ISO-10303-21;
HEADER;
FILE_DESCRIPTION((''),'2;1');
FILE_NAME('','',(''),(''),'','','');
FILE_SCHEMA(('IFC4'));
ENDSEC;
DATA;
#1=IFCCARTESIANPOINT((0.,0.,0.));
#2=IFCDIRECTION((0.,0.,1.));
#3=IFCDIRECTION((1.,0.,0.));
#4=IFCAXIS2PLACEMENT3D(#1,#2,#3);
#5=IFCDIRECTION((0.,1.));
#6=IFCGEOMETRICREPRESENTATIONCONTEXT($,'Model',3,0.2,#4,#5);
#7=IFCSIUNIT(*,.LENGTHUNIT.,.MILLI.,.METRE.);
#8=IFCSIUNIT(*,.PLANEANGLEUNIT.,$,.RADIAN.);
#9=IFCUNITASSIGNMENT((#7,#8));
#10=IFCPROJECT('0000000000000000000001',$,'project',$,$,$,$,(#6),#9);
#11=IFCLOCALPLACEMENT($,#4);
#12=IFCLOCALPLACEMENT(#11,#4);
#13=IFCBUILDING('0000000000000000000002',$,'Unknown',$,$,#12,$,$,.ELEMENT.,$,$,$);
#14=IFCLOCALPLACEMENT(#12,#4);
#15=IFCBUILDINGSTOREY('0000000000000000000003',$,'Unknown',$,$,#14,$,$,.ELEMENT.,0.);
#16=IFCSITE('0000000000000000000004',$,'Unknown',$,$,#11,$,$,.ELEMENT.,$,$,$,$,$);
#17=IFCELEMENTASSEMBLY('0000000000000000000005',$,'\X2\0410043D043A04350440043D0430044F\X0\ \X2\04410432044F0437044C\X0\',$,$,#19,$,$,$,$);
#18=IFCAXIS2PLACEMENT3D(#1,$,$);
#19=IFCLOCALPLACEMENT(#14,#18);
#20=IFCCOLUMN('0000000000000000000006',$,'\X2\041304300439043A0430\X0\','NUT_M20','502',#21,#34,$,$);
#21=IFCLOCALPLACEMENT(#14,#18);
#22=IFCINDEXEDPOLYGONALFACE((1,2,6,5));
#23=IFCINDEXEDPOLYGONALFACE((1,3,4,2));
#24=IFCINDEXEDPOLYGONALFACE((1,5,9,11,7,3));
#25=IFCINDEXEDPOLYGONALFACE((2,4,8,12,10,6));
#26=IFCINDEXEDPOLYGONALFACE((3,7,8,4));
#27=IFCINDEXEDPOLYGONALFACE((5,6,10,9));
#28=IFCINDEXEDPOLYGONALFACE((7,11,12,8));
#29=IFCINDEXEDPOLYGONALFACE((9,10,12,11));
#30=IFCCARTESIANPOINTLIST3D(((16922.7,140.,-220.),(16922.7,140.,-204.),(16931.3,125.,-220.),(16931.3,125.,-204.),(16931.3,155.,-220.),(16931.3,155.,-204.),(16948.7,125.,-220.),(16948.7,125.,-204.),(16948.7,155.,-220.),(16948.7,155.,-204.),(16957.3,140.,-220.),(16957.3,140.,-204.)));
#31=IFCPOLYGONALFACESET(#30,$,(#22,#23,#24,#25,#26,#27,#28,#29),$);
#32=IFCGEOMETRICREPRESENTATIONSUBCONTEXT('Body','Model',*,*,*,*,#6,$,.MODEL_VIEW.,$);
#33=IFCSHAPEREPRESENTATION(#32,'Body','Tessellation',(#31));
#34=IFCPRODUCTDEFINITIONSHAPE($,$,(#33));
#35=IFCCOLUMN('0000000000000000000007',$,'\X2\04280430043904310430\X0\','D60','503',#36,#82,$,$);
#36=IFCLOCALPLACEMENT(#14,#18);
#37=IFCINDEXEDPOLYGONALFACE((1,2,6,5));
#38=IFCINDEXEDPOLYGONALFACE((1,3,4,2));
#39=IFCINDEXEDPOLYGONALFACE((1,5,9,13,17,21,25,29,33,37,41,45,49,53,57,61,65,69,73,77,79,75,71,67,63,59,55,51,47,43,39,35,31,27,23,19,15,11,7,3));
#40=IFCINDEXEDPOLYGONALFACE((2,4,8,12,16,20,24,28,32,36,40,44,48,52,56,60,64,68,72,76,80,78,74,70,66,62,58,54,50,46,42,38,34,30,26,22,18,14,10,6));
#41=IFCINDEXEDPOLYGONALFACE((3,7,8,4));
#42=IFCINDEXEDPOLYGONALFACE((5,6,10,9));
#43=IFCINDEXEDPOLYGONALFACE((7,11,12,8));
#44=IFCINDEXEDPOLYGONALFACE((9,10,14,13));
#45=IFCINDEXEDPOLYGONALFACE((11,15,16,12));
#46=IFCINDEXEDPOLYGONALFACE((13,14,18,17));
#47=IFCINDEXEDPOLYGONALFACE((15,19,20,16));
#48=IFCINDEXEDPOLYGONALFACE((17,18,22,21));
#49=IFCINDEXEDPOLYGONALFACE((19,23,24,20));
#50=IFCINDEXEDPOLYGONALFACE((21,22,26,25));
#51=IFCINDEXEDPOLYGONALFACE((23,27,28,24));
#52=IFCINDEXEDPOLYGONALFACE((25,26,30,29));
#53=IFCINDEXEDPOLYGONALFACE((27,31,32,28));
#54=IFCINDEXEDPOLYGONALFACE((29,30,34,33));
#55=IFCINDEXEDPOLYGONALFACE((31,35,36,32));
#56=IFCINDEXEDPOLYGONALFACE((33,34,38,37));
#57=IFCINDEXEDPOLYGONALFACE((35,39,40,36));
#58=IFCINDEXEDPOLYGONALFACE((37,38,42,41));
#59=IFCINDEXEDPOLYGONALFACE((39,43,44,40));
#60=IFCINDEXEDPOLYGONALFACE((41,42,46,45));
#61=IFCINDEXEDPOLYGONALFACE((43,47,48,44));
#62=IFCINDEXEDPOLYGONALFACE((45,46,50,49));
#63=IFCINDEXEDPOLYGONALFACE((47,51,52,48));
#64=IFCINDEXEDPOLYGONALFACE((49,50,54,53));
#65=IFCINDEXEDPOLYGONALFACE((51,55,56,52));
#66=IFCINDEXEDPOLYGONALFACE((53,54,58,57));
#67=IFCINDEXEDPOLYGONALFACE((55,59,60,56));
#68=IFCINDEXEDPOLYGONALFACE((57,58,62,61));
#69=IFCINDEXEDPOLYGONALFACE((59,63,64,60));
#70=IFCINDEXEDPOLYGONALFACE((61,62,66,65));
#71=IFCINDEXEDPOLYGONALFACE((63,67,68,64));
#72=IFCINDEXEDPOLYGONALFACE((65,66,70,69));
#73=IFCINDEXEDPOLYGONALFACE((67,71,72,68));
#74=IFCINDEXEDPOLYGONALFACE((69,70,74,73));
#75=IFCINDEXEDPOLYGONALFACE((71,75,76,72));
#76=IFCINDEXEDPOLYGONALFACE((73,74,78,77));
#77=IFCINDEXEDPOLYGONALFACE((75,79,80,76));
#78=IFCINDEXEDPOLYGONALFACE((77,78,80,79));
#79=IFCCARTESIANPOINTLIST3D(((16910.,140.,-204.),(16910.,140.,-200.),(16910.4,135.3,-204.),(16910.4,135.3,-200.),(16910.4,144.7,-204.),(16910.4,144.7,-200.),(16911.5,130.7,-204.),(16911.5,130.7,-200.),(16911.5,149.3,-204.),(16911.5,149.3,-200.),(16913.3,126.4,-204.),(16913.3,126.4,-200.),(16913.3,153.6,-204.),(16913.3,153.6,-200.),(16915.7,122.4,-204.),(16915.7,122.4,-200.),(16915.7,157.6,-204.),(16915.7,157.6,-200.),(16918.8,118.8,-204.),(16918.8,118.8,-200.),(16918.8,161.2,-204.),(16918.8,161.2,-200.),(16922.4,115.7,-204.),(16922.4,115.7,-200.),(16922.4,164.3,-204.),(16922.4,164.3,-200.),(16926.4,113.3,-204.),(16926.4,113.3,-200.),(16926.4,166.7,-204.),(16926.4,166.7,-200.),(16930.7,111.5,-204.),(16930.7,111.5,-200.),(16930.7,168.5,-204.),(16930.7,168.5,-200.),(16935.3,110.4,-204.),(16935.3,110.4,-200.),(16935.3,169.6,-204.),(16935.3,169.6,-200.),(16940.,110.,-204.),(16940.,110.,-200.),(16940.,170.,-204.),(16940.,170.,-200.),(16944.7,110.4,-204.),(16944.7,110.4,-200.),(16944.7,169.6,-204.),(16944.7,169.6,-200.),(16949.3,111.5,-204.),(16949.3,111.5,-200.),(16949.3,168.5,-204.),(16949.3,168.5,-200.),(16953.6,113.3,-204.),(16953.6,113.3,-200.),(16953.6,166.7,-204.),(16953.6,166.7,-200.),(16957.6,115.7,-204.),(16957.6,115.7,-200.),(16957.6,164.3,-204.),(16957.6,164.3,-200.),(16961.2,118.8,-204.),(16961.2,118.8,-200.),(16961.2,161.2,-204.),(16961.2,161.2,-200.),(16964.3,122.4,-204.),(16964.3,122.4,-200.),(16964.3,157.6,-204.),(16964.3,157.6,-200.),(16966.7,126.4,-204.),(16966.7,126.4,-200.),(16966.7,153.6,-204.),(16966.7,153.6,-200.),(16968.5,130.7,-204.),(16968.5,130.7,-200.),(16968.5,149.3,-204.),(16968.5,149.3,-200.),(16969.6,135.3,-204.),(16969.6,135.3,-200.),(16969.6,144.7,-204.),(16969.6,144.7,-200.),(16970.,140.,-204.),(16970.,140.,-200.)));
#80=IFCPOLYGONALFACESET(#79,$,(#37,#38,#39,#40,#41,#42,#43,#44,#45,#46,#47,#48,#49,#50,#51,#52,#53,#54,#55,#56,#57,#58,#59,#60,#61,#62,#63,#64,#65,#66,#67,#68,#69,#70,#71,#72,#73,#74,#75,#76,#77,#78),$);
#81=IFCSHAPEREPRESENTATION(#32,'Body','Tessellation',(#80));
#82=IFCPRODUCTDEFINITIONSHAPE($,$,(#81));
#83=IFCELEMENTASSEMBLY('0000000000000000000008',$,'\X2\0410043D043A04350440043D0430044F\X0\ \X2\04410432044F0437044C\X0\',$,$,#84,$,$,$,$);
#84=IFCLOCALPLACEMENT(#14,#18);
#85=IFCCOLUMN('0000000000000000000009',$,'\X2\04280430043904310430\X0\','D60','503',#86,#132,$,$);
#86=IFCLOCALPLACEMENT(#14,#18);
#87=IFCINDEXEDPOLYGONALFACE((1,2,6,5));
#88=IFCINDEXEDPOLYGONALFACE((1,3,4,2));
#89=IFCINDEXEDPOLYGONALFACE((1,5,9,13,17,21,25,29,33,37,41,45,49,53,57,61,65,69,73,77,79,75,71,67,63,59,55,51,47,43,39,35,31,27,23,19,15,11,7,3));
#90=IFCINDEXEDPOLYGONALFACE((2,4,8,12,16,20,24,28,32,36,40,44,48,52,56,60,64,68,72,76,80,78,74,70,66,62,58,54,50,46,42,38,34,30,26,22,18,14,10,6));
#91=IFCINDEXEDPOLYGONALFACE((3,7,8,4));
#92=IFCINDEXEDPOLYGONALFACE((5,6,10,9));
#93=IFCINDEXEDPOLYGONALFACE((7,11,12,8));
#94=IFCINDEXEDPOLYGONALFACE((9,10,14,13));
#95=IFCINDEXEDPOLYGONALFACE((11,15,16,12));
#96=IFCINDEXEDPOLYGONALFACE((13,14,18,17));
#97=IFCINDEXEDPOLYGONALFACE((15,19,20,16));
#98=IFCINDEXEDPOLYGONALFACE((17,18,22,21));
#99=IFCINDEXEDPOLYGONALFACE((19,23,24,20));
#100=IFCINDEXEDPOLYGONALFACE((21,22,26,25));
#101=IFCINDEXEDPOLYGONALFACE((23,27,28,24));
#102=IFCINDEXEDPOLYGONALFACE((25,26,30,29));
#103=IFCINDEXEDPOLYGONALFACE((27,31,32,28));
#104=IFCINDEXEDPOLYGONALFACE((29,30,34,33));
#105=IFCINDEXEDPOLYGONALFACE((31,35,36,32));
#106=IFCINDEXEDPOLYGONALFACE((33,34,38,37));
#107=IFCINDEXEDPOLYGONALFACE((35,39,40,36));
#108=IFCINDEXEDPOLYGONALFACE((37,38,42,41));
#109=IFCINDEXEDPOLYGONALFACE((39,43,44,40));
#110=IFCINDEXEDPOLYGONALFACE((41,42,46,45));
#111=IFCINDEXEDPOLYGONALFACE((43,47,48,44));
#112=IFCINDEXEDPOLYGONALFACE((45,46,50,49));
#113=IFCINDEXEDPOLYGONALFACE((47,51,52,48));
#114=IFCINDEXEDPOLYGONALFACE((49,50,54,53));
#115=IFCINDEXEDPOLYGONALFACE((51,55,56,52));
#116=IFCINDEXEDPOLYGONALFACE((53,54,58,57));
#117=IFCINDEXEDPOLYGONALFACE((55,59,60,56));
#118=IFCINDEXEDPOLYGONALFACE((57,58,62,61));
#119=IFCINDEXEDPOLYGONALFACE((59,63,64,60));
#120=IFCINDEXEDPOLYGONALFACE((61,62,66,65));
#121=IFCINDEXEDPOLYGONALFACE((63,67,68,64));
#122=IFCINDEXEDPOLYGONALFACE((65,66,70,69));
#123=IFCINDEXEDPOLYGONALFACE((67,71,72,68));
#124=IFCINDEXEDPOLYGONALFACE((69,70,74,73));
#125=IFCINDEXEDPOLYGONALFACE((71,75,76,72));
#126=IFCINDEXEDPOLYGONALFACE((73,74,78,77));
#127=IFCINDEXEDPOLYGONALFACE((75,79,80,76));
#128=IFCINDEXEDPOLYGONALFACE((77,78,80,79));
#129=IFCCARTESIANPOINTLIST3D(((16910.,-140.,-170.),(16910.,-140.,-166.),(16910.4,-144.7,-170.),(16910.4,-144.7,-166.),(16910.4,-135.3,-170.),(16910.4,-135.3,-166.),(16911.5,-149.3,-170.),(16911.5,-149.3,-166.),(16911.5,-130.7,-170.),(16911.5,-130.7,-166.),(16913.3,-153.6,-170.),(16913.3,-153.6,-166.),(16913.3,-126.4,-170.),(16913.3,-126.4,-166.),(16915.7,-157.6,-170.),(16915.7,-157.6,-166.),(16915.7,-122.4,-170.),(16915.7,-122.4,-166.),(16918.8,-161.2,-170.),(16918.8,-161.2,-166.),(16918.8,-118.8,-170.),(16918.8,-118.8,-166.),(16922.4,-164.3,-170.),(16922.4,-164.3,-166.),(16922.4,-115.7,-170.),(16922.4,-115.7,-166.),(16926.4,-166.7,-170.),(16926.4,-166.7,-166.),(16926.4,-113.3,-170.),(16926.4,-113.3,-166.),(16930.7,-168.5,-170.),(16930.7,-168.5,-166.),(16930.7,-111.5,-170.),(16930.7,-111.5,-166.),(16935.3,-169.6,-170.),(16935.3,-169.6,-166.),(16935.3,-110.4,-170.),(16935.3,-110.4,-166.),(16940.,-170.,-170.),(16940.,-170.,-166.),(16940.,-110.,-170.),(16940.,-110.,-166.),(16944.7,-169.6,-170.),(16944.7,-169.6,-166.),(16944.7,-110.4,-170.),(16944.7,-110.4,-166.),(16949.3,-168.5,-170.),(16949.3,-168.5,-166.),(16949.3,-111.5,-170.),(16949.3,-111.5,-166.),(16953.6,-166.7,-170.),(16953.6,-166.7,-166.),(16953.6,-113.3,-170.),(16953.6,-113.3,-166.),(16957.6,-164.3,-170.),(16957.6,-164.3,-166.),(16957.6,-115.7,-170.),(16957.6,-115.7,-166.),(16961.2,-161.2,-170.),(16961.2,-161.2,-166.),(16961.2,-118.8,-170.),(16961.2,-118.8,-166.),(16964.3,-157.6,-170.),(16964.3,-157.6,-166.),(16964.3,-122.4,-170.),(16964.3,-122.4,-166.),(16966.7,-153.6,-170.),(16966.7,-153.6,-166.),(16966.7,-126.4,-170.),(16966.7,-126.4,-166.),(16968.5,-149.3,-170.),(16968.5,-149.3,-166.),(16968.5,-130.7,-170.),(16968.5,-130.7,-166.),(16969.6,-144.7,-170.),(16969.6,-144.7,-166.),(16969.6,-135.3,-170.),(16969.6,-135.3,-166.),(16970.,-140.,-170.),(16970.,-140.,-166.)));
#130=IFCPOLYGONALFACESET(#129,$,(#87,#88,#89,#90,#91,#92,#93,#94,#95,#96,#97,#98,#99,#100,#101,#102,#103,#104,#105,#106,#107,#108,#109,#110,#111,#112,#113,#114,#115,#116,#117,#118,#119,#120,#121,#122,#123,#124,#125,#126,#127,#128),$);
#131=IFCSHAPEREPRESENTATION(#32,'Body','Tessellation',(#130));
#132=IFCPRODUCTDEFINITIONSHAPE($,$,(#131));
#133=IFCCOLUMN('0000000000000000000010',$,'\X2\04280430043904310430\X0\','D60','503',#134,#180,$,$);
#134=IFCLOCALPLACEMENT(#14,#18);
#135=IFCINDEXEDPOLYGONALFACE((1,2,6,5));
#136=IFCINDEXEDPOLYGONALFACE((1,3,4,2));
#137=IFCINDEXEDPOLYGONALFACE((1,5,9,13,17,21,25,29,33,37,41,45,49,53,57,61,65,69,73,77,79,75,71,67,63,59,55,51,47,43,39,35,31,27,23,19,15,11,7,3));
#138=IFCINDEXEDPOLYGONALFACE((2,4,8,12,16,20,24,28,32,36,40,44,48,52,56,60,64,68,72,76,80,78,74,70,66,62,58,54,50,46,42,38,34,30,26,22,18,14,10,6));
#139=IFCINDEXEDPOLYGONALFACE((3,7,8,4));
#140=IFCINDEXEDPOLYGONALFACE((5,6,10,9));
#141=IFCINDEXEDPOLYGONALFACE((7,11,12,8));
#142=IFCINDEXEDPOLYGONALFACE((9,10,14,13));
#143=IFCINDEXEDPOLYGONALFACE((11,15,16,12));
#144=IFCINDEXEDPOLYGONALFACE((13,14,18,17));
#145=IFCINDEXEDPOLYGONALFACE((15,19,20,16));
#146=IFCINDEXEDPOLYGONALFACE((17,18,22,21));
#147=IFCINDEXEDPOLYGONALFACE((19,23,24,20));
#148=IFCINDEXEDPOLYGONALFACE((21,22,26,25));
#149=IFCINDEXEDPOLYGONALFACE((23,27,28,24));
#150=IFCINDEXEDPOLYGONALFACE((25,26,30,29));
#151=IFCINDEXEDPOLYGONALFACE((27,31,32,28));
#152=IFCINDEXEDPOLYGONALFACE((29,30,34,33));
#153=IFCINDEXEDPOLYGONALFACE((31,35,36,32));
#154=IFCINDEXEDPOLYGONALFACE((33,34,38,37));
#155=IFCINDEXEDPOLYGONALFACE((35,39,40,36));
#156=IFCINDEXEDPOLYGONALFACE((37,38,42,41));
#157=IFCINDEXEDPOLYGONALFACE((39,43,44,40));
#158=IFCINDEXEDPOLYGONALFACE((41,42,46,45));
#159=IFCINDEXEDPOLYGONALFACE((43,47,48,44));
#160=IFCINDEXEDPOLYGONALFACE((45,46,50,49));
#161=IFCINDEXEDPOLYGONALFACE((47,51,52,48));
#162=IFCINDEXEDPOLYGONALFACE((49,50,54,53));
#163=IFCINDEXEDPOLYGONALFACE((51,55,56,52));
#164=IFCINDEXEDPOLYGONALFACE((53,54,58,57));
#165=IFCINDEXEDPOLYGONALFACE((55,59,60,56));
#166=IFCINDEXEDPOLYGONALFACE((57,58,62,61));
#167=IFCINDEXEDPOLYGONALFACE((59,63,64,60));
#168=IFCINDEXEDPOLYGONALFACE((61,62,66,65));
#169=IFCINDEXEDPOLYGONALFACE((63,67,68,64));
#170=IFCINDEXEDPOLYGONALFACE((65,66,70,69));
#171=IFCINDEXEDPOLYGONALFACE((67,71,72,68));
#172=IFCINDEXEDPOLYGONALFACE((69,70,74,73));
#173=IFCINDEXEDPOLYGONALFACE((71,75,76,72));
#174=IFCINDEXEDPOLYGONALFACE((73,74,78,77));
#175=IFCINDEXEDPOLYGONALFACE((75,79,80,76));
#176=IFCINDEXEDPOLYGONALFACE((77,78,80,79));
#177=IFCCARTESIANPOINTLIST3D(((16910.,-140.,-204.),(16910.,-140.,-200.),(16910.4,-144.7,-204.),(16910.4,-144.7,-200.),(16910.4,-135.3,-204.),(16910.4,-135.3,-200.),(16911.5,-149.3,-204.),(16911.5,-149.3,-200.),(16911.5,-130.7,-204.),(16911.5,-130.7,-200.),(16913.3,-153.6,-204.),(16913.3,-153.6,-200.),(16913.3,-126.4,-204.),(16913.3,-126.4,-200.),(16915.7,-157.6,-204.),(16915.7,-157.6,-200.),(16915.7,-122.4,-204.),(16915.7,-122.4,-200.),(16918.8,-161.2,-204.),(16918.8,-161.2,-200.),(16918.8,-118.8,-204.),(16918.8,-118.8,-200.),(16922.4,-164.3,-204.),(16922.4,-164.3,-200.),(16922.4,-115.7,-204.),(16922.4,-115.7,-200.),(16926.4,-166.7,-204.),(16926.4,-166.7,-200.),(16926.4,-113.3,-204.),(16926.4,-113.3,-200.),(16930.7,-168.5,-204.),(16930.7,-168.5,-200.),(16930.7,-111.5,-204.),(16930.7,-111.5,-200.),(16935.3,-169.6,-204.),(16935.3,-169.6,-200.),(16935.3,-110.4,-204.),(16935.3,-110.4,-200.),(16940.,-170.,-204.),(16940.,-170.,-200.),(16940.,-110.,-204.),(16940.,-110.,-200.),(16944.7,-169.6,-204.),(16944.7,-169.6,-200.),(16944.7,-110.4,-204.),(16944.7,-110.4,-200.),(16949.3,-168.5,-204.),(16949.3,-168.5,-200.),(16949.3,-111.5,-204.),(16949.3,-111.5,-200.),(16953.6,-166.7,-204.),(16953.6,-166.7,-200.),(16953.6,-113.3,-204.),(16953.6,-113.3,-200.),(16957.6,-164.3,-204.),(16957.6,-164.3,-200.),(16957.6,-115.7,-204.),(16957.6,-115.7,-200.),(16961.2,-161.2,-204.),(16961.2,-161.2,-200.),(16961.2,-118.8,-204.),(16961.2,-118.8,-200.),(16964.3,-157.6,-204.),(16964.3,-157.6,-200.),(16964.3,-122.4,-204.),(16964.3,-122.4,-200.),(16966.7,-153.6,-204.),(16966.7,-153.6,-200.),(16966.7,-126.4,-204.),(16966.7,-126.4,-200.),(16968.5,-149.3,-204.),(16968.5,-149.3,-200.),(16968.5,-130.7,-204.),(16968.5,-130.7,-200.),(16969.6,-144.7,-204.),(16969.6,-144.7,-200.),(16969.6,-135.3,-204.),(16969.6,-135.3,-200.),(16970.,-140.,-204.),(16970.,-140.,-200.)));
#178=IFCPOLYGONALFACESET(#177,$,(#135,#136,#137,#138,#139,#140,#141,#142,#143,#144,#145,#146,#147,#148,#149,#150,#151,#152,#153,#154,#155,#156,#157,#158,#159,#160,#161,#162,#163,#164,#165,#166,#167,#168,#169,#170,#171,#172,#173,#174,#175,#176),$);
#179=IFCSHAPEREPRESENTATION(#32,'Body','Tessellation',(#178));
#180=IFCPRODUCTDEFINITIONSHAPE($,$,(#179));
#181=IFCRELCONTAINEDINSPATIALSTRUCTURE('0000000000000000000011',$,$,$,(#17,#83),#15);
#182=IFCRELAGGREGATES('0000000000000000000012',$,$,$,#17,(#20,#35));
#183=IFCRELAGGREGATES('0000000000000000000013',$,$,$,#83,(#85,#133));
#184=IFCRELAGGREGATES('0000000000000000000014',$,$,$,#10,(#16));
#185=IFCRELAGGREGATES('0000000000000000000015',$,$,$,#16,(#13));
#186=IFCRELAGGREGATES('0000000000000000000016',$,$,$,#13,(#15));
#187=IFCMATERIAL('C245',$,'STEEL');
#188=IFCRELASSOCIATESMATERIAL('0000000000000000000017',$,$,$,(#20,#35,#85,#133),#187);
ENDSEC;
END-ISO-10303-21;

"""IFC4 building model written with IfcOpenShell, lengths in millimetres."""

from ifc_helpers import new_model, si_unit, direction, frame, origin_with_axes, place, context, subcontext, project, spatial, line, indexed_curve, outline, extrude, material, element, aggregate, save


model = new_model("IFC4")

# Units and contexts
model_context = context("Model", 3, precision=0.2, world=origin_with_axes(), true_north=direction((0.0, 1.0)))
body_context = subcontext(model_context, "Body", "Model", "MODEL_VIEW")
ifc_project = project(units=[si_unit("LENGTHUNIT", "METRE", prefix="MILLI"), si_unit("PLANEANGLEUNIT", "RADIAN")], contexts=[model_context])

# Site, building, storey
site_placement = place(None, origin_with_axes())
site = spatial("IfcSite", under=ifc_project, at=site_placement, Name="Unknown", CompositionType="ELEMENT")
building_placement = place(site_placement, origin_with_axes())
building = spatial("IfcBuilding", under=site, at=building_placement, Name="Unknown", CompositionType="ELEMENT")
storey_placement = place(building_placement, origin_with_axes())
storey = spatial("IfcBuildingStorey", under=building, at=storey_placement, Name="Unknown", CompositionType="ELEMENT", Elevation=0.0)

# Element assemblies, columns
assembly_1_placement = place(storey_placement, frame((16940.0, 140.0, -125.0), z_axis=(-1.0, 0.0, 0.0), x_axis=(0.0, 0.0, -1.0)))
assembly_1 = element("IfcElementAssembly", 1, at=assembly_1_placement, inside=storey, Name="Анкерная связь")
ifc_material_1 = material(Name="C245", Category="STEEL")
column_1_placement = place(assembly_1_placement, frame((79.0, 0.0, 0.0), z_axis=(0.0, 0.0, -1.0), x_axis=(1.0, 0.0, 0.0)))
column_1 = element("IfcColumn", 2, at=column_1_placement, material=ifc_material_1, Name="Гайка", Description="NUT_M20", ObjectType="502", context=body_context, shape_type="SolidModel", body=[
    extrude(outline(indexed_curve([(8.7, -15.0), (17.3, 0.0), (8.7, 15.0), (-8.7, 15.0), (-17.3, 0.0), (-8.7, -15.0)], segments=[line(1, 2, 3, 4, 5, 6, 1)])), frame((0.0, 0.0, 0.0), z_axis=(-1.0, 0.0, 0.0), x_axis=(0.0, 0.0, 1.0)), (0.0, 0.0, -1.0), 16.0),
])
column_2_placement = place(assembly_1_placement, frame((75.0, 0.0, 0.0), z_axis=(0.0, -1.0, 0.0), x_axis=(1.0, 0.0, 0.0)))
column_2 = element("IfcColumn", 3, at=column_2_placement, material=ifc_material_1, Name="Шайба", Description="D60", ObjectType="503", context=body_context, shape_type="SolidModel", body=[
    extrude(outline(indexed_curve([(30.0, 0.0), (29.6, 4.7), (28.5, 9.3), (26.7, 13.6), (24.3, 17.6), (21.2, 21.2), (17.6, 24.3), (13.6, 26.7), (9.3, 28.5), (4.7, 29.6), (0.0, 30.0), (-4.7, 29.6), (-9.3, 28.5), (-13.6, 26.7), (-17.6, 24.3), (-21.2, 21.2), (-24.3, 17.6), (-26.7, 13.6), (-28.5, 9.3), (-29.6, 4.7), (-30.0, 0.0), (-29.6, -4.7), (-28.5, -9.3), (-26.7, -13.6), (-24.3, -17.6), (-21.2, -21.2), (-17.6, -24.3), (-13.6, -26.7), (-9.3, -28.5), (-4.7, -29.6), (0.0, -30.0), (4.7, -29.6), (9.3, -28.5), (13.6, -26.7), (17.6, -24.3), (21.2, -21.2), (24.3, -17.6), (26.7, -13.6), (28.5, -9.3), (29.6, -4.7)], segments=[line(1, 2, 3, 4, 5, 6, 7, 8, 9, 10, 11, 12, 13, 14, 15, 16, 17, 18, 19, 20, 21, 22, 23, 24, 25, 26, 27, 28, 29, 30, 31, 32, 33, 34, 35, 36, 37, 38, 39, 40, 1)])), frame((0.0, 0.0, 0.0), z_axis=(-1.0, 0.0, 0.0), x_axis=(0.0, 0.0, 1.0)), (0.0, 0.0, -1.0), 4.0),
])
assembly_2_placement = place(storey_placement, frame((16940.0, -140.0, -125.0), z_axis=(1.0, 0.0, 0.0), x_axis=(0.0, 0.0, -1.0)))
assembly_2 = element("IfcElementAssembly", 4, at=assembly_2_placement, inside=storey, Name="Анкерная связь")
column_3_placement = place(assembly_2_placement, frame((41.0, 0.0, 0.0), z_axis=(0.0, 0.0, 1.0), x_axis=(1.0, 0.0, 0.0)))
column_3 = element("IfcColumn", 5, at=column_3_placement, material=ifc_material_1, Name="Шайба", Description="D60", ObjectType="503", context=body_context, shape_type="SolidModel", body=[
    extrude(outline(indexed_curve([(30.0, 0.0), (29.6, 4.7), (28.5, 9.3), (26.7, 13.6), (24.3, 17.6), (21.2, 21.2), (17.6, 24.3), (13.6, 26.7), (9.3, 28.5), (4.7, 29.6), (0.0, 30.0), (-4.7, 29.6), (-9.3, 28.5), (-13.6, 26.7), (-17.6, 24.3), (-21.2, 21.2), (-24.3, 17.6), (-26.7, 13.6), (-28.5, 9.3), (-29.6, 4.7), (-30.0, 0.0), (-29.6, -4.7), (-28.5, -9.3), (-26.7, -13.6), (-24.3, -17.6), (-21.2, -21.2), (-17.6, -24.3), (-13.6, -26.7), (-9.3, -28.5), (-4.7, -29.6), (0.0, -30.0), (4.7, -29.6), (9.3, -28.5), (13.6, -26.7), (17.6, -24.3), (21.2, -21.2), (24.3, -17.6), (26.7, -13.6), (28.5, -9.3), (29.6, -4.7)], segments=[line(1, 2, 3, 4, 5, 6, 7, 8, 9, 10, 11, 12, 13, 14, 15, 16, 17, 18, 19, 20, 21, 22, 23, 24, 25, 26, 27, 28, 29, 30, 31, 32, 33, 34, 35, 36, 37, 38, 39, 40, 1)])), frame((0.0, 0.0, 0.0), z_axis=(-1.0, 0.0, 0.0), x_axis=(0.0, 0.0, 1.0)), (0.0, 0.0, -1.0), 4.0),
])
column_4_placement = place(assembly_2_placement, frame((75.0, 0.0, 0.0), z_axis=(0.0, 1.0, 0.0), x_axis=(1.0, 0.0, 0.0)))
column_4 = element("IfcColumn", 6, at=column_4_placement, material=ifc_material_1, Name="Шайба", Description="D60", ObjectType="503", context=body_context, shape_type="SolidModel", body=[
    extrude(outline(indexed_curve([(30.0, 0.0), (29.6, 4.7), (28.5, 9.3), (26.7, 13.6), (24.3, 17.6), (21.2, 21.2), (17.6, 24.3), (13.6, 26.7), (9.3, 28.5), (4.7, 29.6), (0.0, 30.0), (-4.7, 29.6), (-9.3, 28.5), (-13.6, 26.7), (-17.6, 24.3), (-21.2, 21.2), (-24.3, 17.6), (-26.7, 13.6), (-28.5, 9.3), (-29.6, 4.7), (-30.0, 0.0), (-29.6, -4.7), (-28.5, -9.3), (-26.7, -13.6), (-24.3, -17.6), (-21.2, -21.2), (-17.6, -24.3), (-13.6, -26.7), (-9.3, -28.5), (-4.7, -29.6), (0.0, -30.0), (4.7, -29.6), (9.3, -28.5), (13.6, -26.7), (17.6, -24.3), (21.2, -21.2), (24.3, -17.6), (26.7, -13.6), (28.5, -9.3), (29.6, -4.7)], segments=[line(1, 2, 3, 4, 5, 6, 7, 8, 9, 10, 11, 12, 13, 14, 15, 16, 17, 18, 19, 20, 21, 22, 23, 24, 25, 26, 27, 28, 29, 30, 31, 32, 33, 34, 35, 36, 37, 38, 39, 40, 1)])), frame((0.0, 0.0, 0.0), z_axis=(-1.0, 0.0, 0.0), x_axis=(0.0, 0.0, 1.0)), (0.0, 0.0, -1.0), 4.0),
])

aggregate(assembly_1, [column_1, column_2])
aggregate(assembly_2, [column_3, column_4])

save(model, "model.ifc")
